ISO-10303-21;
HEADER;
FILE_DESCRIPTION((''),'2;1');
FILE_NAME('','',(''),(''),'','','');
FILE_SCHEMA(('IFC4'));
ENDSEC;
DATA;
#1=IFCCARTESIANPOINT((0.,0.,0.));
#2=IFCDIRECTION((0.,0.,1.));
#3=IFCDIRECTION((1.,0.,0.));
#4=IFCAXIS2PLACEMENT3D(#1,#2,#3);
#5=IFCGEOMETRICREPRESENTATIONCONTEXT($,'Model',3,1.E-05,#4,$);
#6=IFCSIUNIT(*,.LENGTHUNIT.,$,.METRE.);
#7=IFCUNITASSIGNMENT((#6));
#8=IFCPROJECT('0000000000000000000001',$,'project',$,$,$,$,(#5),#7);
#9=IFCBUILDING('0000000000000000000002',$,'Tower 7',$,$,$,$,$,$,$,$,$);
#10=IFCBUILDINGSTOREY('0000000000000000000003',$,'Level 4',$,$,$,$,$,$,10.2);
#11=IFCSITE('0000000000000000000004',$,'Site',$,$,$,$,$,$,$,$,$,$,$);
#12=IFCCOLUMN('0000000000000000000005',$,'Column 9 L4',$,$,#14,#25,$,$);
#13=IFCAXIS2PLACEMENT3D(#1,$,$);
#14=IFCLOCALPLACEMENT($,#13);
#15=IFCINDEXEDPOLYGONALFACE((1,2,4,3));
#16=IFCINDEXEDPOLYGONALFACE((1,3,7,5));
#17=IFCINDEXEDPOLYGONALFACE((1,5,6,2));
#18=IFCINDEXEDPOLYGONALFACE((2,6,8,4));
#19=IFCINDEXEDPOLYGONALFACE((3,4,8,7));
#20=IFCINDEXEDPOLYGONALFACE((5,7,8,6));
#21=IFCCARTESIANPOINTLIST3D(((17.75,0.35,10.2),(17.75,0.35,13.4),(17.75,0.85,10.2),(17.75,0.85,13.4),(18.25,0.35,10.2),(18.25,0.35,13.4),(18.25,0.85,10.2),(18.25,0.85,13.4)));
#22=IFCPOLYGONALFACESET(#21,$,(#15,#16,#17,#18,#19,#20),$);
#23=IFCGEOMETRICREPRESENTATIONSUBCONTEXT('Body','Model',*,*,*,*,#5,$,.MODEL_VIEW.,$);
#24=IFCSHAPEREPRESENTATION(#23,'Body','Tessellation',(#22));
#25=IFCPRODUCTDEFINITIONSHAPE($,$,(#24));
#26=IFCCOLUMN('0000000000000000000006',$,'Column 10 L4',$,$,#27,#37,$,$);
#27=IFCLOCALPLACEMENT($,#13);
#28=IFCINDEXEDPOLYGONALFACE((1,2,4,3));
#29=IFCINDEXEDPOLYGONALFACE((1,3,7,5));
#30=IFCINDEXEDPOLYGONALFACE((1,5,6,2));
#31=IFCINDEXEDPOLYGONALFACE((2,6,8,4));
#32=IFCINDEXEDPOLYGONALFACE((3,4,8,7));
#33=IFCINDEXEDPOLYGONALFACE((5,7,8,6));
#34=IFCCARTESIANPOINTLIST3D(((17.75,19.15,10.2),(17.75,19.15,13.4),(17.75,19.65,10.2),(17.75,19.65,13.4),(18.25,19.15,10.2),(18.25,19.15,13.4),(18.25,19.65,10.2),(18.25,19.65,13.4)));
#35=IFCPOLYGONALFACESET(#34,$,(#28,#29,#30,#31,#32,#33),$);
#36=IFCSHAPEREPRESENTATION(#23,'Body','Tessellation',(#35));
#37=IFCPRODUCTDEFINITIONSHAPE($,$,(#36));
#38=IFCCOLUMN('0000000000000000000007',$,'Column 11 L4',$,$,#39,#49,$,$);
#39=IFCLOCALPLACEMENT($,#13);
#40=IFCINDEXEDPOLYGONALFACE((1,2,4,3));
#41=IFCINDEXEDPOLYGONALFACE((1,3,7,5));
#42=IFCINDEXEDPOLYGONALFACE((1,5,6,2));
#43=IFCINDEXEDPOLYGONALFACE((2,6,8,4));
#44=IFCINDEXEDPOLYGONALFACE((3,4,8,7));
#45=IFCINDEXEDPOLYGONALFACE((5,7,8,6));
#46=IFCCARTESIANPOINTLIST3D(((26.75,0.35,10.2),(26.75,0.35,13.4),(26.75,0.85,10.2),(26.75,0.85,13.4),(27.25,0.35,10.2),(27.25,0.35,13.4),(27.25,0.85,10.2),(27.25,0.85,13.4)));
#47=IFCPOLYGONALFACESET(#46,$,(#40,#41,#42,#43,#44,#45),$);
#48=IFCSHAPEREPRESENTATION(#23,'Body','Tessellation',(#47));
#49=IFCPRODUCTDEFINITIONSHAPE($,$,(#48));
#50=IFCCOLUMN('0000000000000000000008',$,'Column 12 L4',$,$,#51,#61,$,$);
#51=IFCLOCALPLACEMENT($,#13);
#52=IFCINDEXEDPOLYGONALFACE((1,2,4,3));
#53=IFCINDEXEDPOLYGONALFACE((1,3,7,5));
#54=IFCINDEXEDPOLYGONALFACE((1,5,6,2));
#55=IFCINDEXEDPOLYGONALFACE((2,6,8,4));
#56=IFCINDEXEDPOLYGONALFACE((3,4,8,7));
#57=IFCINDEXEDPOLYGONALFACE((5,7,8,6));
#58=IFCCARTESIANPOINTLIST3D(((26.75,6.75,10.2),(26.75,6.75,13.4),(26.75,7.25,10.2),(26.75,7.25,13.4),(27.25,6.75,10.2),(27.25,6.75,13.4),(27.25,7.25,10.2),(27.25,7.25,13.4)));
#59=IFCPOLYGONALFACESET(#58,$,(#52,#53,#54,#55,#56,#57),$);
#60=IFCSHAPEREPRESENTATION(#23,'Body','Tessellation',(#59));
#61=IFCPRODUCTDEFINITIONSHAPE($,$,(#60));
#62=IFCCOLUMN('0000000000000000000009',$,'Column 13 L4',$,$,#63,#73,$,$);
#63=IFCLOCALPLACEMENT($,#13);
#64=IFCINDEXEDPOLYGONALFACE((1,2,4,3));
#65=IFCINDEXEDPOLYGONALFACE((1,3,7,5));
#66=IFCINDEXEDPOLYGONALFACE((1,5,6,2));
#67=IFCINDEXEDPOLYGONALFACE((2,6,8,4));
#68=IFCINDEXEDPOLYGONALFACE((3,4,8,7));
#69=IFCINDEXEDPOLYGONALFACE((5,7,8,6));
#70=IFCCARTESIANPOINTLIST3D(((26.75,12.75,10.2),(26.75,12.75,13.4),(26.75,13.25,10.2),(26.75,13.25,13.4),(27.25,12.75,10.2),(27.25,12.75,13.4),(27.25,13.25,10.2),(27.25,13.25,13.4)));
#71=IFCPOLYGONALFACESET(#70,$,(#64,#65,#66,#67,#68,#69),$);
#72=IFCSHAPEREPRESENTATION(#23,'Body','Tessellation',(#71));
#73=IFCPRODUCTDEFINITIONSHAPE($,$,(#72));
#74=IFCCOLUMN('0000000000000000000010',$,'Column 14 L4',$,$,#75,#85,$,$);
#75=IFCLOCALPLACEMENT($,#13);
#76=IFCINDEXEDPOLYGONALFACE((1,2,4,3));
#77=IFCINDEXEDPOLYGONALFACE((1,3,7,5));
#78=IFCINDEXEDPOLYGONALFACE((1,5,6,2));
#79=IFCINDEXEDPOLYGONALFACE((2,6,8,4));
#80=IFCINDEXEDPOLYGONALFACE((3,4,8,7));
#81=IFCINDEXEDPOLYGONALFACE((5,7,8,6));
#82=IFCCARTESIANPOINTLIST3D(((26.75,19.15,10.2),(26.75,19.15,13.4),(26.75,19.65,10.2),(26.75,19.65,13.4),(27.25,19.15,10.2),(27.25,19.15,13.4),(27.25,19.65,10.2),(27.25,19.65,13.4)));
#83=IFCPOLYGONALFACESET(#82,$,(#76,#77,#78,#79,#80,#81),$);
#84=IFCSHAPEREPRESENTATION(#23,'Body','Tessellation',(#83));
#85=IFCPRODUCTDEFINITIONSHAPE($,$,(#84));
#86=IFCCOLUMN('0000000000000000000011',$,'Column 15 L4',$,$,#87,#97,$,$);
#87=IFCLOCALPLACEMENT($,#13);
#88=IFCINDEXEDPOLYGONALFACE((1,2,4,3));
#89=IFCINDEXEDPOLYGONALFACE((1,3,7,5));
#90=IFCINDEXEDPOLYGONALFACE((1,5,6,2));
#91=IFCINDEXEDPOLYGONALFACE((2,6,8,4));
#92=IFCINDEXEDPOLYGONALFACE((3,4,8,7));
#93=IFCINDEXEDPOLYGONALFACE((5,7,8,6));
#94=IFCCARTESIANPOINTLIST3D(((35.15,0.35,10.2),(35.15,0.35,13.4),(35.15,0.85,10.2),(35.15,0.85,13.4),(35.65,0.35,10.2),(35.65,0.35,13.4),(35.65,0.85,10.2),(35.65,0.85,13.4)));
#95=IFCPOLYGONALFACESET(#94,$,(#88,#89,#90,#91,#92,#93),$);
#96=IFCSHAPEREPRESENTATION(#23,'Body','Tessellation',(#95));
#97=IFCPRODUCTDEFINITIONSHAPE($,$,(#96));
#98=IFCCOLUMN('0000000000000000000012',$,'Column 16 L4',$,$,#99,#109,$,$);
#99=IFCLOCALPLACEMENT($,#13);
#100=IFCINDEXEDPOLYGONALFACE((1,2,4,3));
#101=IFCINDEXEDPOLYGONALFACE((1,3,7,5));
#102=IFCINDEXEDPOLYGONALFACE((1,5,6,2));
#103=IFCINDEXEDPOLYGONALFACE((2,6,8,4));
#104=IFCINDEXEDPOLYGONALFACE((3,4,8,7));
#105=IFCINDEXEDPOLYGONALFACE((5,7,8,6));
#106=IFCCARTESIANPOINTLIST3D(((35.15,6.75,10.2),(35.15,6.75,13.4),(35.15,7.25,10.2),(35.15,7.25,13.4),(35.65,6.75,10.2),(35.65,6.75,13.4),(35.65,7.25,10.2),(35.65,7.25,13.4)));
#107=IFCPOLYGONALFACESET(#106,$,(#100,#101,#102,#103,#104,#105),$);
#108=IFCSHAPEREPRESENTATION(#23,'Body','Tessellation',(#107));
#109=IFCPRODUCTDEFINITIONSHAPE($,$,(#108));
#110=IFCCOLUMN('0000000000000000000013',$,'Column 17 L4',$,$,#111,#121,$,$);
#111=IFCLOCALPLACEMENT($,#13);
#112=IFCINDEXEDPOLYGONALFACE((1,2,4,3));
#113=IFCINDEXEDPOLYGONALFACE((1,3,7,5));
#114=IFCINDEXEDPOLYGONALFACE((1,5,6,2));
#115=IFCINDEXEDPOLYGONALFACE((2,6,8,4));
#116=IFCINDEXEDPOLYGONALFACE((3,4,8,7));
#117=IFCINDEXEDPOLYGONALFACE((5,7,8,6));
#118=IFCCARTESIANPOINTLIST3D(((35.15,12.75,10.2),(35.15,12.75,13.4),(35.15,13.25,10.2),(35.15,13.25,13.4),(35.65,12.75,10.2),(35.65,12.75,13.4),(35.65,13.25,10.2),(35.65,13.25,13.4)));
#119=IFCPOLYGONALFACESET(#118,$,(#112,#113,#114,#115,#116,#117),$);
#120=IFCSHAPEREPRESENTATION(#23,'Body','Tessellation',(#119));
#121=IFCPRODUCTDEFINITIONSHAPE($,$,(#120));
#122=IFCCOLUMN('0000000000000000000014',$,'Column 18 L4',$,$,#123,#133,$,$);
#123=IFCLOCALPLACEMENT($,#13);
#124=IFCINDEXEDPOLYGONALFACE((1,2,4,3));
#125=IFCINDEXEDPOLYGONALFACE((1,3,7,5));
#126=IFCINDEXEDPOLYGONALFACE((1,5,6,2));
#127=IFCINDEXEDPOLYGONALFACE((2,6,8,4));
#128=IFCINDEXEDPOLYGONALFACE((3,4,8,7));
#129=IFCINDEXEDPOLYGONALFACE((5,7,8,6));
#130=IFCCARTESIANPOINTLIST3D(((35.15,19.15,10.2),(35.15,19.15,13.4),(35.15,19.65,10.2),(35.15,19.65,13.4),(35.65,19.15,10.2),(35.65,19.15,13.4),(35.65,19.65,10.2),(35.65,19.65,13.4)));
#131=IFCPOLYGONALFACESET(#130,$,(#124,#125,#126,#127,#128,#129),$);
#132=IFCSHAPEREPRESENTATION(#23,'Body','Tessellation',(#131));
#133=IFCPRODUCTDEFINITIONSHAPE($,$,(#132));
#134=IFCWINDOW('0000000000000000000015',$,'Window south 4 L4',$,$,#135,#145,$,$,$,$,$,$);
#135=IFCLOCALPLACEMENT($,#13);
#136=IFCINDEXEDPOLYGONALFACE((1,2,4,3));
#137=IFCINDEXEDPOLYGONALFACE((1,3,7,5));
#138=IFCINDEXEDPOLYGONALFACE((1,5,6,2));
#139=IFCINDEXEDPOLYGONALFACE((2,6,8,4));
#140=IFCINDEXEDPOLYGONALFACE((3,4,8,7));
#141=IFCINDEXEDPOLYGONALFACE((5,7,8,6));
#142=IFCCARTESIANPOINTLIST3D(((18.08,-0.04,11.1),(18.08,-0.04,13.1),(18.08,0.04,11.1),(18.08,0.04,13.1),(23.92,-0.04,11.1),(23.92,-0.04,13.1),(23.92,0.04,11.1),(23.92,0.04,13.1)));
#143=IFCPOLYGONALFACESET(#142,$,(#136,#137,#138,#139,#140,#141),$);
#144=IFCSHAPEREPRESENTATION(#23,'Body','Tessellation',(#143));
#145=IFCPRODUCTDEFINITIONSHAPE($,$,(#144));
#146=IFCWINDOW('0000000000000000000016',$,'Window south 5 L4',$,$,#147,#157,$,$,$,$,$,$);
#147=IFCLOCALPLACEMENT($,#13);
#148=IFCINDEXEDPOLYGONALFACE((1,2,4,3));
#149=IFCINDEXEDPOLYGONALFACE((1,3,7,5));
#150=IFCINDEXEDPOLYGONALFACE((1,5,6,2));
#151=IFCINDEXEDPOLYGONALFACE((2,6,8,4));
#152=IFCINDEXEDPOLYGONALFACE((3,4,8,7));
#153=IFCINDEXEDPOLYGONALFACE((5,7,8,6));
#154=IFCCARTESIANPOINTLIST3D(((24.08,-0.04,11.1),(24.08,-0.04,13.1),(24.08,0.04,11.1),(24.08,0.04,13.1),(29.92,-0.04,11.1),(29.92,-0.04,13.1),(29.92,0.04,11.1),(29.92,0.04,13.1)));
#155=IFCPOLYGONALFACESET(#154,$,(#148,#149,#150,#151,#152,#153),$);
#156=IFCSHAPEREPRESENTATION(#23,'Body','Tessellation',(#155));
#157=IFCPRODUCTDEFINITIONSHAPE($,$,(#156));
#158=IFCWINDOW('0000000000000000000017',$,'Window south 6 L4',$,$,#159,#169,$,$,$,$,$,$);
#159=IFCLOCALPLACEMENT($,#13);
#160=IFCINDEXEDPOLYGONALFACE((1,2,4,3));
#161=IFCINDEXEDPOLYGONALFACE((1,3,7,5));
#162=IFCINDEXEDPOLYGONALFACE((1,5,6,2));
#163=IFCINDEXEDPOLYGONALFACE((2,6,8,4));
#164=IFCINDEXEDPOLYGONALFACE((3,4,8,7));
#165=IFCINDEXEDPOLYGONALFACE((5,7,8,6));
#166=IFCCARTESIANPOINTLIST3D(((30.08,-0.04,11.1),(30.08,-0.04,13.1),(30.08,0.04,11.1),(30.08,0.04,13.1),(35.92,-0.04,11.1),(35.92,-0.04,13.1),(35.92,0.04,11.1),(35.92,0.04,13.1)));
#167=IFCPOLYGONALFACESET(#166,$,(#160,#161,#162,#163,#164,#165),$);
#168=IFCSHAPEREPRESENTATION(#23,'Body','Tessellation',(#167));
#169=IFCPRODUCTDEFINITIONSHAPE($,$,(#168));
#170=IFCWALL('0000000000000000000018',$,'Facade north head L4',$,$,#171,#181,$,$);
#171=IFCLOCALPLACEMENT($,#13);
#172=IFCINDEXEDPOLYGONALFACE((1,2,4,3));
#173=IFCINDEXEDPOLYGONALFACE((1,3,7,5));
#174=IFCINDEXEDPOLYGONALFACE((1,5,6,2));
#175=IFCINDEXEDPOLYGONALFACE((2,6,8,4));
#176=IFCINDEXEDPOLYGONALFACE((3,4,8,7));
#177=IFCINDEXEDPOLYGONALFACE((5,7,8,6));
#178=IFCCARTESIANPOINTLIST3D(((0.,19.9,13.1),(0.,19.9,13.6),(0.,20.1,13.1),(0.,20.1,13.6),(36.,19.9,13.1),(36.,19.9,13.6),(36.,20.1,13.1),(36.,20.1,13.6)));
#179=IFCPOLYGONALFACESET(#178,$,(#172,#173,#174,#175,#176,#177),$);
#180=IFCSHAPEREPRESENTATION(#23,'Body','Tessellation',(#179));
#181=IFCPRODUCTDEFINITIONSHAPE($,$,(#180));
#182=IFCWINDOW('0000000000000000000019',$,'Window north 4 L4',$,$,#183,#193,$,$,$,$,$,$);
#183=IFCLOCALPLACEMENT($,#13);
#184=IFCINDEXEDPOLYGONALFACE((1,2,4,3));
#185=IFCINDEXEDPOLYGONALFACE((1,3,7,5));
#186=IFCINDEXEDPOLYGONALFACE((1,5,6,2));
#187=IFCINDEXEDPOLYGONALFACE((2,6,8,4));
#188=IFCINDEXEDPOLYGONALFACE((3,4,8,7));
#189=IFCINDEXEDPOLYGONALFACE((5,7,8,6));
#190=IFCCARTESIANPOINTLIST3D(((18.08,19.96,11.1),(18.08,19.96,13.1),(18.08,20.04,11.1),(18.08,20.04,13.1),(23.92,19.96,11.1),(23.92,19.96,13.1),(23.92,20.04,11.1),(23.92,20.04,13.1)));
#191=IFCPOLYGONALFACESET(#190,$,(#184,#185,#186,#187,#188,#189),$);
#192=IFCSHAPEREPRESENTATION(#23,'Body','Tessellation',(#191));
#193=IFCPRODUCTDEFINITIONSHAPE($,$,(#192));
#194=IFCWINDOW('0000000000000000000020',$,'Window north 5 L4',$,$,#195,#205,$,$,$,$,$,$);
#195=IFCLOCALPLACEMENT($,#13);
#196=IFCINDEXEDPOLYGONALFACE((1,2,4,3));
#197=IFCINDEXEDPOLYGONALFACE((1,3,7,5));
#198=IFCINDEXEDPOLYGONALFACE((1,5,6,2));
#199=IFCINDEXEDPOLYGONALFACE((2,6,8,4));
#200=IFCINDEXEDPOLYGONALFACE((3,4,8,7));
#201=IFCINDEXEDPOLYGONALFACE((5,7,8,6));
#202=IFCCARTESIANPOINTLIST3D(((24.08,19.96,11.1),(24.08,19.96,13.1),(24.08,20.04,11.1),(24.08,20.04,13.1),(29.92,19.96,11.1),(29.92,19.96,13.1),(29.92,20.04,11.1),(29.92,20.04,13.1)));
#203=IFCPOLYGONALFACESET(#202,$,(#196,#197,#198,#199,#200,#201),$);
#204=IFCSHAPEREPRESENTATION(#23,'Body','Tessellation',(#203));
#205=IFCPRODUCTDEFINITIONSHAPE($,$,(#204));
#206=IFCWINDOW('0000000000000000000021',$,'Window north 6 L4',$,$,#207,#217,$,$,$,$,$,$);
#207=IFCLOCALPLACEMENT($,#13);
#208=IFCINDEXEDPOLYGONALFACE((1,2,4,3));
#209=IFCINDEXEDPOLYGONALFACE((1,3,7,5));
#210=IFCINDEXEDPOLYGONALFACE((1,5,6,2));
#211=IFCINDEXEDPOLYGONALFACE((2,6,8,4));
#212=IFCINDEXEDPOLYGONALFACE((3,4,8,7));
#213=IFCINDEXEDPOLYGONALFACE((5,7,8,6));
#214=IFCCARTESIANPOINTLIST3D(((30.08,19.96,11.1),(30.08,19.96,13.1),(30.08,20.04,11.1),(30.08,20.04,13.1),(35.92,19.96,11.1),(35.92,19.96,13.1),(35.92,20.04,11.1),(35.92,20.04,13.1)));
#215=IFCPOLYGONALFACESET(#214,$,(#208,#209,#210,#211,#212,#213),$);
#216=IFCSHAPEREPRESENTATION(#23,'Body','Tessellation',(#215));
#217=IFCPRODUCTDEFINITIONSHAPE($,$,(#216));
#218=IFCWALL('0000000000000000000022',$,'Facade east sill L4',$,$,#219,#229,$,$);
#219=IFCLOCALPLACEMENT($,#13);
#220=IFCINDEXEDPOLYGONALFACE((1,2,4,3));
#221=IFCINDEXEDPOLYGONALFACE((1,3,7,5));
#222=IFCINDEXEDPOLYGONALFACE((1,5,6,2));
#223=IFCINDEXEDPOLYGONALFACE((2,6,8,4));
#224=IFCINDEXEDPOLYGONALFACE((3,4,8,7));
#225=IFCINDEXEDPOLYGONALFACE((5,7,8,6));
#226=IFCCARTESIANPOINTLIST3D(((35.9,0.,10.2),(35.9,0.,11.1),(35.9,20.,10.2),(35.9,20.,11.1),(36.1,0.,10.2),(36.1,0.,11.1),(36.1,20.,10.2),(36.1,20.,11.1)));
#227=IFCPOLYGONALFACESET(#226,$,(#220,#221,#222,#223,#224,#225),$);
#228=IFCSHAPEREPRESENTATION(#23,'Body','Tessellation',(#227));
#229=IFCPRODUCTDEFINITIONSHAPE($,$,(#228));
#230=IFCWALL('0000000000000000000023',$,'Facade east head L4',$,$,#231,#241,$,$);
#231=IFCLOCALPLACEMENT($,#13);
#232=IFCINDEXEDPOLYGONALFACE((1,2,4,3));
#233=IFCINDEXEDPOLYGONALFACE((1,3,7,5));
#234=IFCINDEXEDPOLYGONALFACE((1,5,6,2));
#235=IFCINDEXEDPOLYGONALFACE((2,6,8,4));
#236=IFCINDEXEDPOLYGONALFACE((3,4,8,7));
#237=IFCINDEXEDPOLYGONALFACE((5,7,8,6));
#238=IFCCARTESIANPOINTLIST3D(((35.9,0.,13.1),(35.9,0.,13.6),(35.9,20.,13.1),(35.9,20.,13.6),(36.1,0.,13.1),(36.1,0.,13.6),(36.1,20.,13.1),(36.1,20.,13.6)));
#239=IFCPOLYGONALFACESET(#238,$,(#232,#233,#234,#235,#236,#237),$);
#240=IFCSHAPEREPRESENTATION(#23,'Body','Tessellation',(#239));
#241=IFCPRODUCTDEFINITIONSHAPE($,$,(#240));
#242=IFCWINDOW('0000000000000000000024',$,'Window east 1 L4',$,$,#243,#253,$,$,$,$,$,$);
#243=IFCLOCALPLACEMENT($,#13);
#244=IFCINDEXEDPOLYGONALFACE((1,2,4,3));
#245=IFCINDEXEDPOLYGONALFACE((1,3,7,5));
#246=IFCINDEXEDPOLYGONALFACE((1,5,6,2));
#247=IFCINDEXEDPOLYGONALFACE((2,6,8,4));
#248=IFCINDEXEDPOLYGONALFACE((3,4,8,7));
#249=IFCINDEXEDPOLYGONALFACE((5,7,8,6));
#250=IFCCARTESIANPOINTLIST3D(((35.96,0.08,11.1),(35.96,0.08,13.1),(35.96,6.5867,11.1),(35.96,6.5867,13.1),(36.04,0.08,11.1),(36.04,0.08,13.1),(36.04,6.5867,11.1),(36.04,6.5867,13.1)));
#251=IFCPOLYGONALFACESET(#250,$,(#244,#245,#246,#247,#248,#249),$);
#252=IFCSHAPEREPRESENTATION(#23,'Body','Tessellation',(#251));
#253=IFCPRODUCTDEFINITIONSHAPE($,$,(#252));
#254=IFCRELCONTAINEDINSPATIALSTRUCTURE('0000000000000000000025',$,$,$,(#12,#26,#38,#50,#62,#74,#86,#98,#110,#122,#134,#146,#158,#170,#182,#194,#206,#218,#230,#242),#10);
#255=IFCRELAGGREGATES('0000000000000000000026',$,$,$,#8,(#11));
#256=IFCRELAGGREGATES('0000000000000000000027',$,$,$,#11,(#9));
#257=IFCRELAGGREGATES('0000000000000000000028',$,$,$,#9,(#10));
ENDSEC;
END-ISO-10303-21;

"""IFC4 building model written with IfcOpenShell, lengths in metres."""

from ifc_helpers import new_model, si_unit, frame, origin, origin_with_axes, origin_2d, place, context, subcontext, project, spatial, rectangle, extrude, element, save


model = new_model("IFC4")

# Units and contexts
model_context = context("Model", 3, precision=1e-05, world=origin_with_axes())
body_context = subcontext(model_context, "Body", "Model", "MODEL_VIEW")
ifc_project = project(units=[si_unit("LENGTHUNIT", "METRE")], contexts=[model_context])

# Site, building, storey
site = spatial("IfcSite", under=ifc_project, Name="Site")
building = spatial("IfcBuilding", under=site, Name="Tower 7")
storey = spatial("IfcBuildingStorey", under=building, Name="Level 4", Elevation=10.2)

# Columns
for number, where, z_axis, x_axis, name in (
    (1, (18.0, 0.6, 10.2), (0.0, 0.0, 1.0), (1.0, 0.0, 0.0), "Column 9 L4"),
    (2, (18.0, 19.4, 10.2), (0.0, 0.0, 1.0), (1.0, 0.0, 0.0), "Column 10 L4"),
    (3, (27.0, 0.6, 10.2), (0.0, 0.0, 1.0), (1.0, 0.0, 0.0), "Column 11 L4"),
    (4, (27.0, 7.0, 10.2), (0.0, 0.0, 1.0), (1.0, 0.0, 0.0), "Column 12 L4"),
    (5, (27.0, 13.0, 10.2), (0.0, 0.0, 1.0), (1.0, 0.0, 0.0), "Column 13 L4"),
    (6, (27.0, 19.4, 10.2), (0.0, 0.0, 1.0), (1.0, 0.0, 0.0), "Column 14 L4"),
    (7, (35.4, 0.6, 10.2), (0.0, 0.0, 1.0), (1.0, 0.0, 0.0), "Column 15 L4"),
    (8, (35.4, 7.0, 10.2), (0.0, 0.0, 1.0), (1.0, 0.0, 0.0), "Column 16 L4"),
    (9, (35.4, 13.0, 10.2), (0.0, 0.0, 1.0), (1.0, 0.0, 0.0), "Column 17 L4"),
    (10, (35.4, 19.4, 10.2), (0.0, 0.0, 1.0), (1.0, 0.0, 0.0), "Column 18 L4"),
):
    element("IfcColumn", number, at=place(None, frame(where, z_axis=z_axis, x_axis=x_axis)), inside=storey, Name=name, context=body_context, shape_type="SweptSolid", body=[
        extrude(rectangle(XDim=0.5, YDim=0.5, at=origin_2d()), origin(), (0.0, 0.0, 1.0), 3.2),
    ])

# Windows
for number, where, z_axis, x_axis, name in (
    (11, (21.0, 0.0, 11.1), (0.0, 0.0, 1.0), (1.0, 0.0, 0.0), "Window south 4 L4"),
    (12, (27.0, 0.0, 11.1), (0.0, 0.0, 1.0), (1.0, 0.0, 0.0), "Window south 5 L4"),
    (13, (33.0, 0.0, 11.1), (0.0, 0.0, 1.0), (1.0, 0.0, 0.0), "Window south 6 L4"),
):
    element("IfcWindow", number, at=place(None, frame(where, z_axis=z_axis, x_axis=x_axis)), inside=storey, Name=name, context=body_context, shape_type="SweptSolid", body=[
        extrude(rectangle(XDim=5.84, YDim=0.08, at=origin_2d()), origin(), (0.0, 0.0, 1.0), 2.0),
    ])

# Wall
wall_1_placement = place(None, frame((18.0, 20.0, 13.1), z_axis=(0.0, 0.0, 1.0), x_axis=(1.0, 0.0, 0.0)))
element("IfcWall", 14, at=wall_1_placement, inside=storey, Name="Facade north head L4", context=body_context, shape_type="SweptSolid", body=[
    extrude(rectangle(XDim=36.0, YDim=0.2, at=origin_2d()), origin(), (0.0, 0.0, 1.0), 0.5),
])

# Windows
for number, where, z_axis, x_axis, name in (
    (15, (21.0, 20.0, 11.1), (0.0, 0.0, 1.0), (1.0, 0.0, 0.0), "Window north 4 L4"),
    (16, (27.0, 20.0, 11.1), (0.0, 0.0, 1.0), (1.0, 0.0, 0.0), "Window north 5 L4"),
    (17, (33.0, 20.0, 11.1), (0.0, 0.0, 1.0), (1.0, 0.0, 0.0), "Window north 6 L4"),
):
    element("IfcWindow", number, at=place(None, frame(where, z_axis=z_axis, x_axis=x_axis)), inside=storey, Name=name, context=body_context, shape_type="SweptSolid", body=[
        extrude(rectangle(XDim=5.84, YDim=0.08, at=origin_2d()), origin(), (0.0, 0.0, 1.0), 2.0),
    ])

# Walls
wall_2_placement = place(None, frame((36.0, 10.0, 10.2), z_axis=(0.0, 0.0, 1.0), x_axis=(1.0, 0.0, 0.0)))
element("IfcWall", 18, at=wall_2_placement, inside=storey, Name="Facade east sill L4", context=body_context, shape_type="SweptSolid", body=[
    extrude(rectangle(XDim=0.2, YDim=20.0, at=origin_2d()), origin(), (0.0, 0.0, 1.0), 0.9),
])
wall_3_placement = place(None, frame((36.0, 10.0, 13.1), z_axis=(0.0, 0.0, 1.0), x_axis=(1.0, 0.0, 0.0)))
element("IfcWall", 19, at=wall_3_placement, inside=storey, Name="Facade east head L4", context=body_context, shape_type="SweptSolid", body=[
    extrude(rectangle(XDim=0.2, YDim=20.0, at=origin_2d()), origin(), (0.0, 0.0, 1.0), 0.5),
])

# Window
for number, where, z_axis, x_axis, name in (
    (20, (36.0, 3.3333, 11.1), (0.0, 0.0, 1.0), (1.0, 0.0, 0.0), "Window east 1 L4"),
):
    element("IfcWindow", number, at=place(None, frame(where, z_axis=z_axis, x_axis=x_axis)), inside=storey, Name=name, context=body_context, shape_type="SweptSolid", body=[
        extrude(rectangle(XDim=0.08, YDim=6.5067, at=origin_2d()), origin(), (0.0, 0.0, 1.0), 2.0),
    ])

save(model, "model.ifc")
